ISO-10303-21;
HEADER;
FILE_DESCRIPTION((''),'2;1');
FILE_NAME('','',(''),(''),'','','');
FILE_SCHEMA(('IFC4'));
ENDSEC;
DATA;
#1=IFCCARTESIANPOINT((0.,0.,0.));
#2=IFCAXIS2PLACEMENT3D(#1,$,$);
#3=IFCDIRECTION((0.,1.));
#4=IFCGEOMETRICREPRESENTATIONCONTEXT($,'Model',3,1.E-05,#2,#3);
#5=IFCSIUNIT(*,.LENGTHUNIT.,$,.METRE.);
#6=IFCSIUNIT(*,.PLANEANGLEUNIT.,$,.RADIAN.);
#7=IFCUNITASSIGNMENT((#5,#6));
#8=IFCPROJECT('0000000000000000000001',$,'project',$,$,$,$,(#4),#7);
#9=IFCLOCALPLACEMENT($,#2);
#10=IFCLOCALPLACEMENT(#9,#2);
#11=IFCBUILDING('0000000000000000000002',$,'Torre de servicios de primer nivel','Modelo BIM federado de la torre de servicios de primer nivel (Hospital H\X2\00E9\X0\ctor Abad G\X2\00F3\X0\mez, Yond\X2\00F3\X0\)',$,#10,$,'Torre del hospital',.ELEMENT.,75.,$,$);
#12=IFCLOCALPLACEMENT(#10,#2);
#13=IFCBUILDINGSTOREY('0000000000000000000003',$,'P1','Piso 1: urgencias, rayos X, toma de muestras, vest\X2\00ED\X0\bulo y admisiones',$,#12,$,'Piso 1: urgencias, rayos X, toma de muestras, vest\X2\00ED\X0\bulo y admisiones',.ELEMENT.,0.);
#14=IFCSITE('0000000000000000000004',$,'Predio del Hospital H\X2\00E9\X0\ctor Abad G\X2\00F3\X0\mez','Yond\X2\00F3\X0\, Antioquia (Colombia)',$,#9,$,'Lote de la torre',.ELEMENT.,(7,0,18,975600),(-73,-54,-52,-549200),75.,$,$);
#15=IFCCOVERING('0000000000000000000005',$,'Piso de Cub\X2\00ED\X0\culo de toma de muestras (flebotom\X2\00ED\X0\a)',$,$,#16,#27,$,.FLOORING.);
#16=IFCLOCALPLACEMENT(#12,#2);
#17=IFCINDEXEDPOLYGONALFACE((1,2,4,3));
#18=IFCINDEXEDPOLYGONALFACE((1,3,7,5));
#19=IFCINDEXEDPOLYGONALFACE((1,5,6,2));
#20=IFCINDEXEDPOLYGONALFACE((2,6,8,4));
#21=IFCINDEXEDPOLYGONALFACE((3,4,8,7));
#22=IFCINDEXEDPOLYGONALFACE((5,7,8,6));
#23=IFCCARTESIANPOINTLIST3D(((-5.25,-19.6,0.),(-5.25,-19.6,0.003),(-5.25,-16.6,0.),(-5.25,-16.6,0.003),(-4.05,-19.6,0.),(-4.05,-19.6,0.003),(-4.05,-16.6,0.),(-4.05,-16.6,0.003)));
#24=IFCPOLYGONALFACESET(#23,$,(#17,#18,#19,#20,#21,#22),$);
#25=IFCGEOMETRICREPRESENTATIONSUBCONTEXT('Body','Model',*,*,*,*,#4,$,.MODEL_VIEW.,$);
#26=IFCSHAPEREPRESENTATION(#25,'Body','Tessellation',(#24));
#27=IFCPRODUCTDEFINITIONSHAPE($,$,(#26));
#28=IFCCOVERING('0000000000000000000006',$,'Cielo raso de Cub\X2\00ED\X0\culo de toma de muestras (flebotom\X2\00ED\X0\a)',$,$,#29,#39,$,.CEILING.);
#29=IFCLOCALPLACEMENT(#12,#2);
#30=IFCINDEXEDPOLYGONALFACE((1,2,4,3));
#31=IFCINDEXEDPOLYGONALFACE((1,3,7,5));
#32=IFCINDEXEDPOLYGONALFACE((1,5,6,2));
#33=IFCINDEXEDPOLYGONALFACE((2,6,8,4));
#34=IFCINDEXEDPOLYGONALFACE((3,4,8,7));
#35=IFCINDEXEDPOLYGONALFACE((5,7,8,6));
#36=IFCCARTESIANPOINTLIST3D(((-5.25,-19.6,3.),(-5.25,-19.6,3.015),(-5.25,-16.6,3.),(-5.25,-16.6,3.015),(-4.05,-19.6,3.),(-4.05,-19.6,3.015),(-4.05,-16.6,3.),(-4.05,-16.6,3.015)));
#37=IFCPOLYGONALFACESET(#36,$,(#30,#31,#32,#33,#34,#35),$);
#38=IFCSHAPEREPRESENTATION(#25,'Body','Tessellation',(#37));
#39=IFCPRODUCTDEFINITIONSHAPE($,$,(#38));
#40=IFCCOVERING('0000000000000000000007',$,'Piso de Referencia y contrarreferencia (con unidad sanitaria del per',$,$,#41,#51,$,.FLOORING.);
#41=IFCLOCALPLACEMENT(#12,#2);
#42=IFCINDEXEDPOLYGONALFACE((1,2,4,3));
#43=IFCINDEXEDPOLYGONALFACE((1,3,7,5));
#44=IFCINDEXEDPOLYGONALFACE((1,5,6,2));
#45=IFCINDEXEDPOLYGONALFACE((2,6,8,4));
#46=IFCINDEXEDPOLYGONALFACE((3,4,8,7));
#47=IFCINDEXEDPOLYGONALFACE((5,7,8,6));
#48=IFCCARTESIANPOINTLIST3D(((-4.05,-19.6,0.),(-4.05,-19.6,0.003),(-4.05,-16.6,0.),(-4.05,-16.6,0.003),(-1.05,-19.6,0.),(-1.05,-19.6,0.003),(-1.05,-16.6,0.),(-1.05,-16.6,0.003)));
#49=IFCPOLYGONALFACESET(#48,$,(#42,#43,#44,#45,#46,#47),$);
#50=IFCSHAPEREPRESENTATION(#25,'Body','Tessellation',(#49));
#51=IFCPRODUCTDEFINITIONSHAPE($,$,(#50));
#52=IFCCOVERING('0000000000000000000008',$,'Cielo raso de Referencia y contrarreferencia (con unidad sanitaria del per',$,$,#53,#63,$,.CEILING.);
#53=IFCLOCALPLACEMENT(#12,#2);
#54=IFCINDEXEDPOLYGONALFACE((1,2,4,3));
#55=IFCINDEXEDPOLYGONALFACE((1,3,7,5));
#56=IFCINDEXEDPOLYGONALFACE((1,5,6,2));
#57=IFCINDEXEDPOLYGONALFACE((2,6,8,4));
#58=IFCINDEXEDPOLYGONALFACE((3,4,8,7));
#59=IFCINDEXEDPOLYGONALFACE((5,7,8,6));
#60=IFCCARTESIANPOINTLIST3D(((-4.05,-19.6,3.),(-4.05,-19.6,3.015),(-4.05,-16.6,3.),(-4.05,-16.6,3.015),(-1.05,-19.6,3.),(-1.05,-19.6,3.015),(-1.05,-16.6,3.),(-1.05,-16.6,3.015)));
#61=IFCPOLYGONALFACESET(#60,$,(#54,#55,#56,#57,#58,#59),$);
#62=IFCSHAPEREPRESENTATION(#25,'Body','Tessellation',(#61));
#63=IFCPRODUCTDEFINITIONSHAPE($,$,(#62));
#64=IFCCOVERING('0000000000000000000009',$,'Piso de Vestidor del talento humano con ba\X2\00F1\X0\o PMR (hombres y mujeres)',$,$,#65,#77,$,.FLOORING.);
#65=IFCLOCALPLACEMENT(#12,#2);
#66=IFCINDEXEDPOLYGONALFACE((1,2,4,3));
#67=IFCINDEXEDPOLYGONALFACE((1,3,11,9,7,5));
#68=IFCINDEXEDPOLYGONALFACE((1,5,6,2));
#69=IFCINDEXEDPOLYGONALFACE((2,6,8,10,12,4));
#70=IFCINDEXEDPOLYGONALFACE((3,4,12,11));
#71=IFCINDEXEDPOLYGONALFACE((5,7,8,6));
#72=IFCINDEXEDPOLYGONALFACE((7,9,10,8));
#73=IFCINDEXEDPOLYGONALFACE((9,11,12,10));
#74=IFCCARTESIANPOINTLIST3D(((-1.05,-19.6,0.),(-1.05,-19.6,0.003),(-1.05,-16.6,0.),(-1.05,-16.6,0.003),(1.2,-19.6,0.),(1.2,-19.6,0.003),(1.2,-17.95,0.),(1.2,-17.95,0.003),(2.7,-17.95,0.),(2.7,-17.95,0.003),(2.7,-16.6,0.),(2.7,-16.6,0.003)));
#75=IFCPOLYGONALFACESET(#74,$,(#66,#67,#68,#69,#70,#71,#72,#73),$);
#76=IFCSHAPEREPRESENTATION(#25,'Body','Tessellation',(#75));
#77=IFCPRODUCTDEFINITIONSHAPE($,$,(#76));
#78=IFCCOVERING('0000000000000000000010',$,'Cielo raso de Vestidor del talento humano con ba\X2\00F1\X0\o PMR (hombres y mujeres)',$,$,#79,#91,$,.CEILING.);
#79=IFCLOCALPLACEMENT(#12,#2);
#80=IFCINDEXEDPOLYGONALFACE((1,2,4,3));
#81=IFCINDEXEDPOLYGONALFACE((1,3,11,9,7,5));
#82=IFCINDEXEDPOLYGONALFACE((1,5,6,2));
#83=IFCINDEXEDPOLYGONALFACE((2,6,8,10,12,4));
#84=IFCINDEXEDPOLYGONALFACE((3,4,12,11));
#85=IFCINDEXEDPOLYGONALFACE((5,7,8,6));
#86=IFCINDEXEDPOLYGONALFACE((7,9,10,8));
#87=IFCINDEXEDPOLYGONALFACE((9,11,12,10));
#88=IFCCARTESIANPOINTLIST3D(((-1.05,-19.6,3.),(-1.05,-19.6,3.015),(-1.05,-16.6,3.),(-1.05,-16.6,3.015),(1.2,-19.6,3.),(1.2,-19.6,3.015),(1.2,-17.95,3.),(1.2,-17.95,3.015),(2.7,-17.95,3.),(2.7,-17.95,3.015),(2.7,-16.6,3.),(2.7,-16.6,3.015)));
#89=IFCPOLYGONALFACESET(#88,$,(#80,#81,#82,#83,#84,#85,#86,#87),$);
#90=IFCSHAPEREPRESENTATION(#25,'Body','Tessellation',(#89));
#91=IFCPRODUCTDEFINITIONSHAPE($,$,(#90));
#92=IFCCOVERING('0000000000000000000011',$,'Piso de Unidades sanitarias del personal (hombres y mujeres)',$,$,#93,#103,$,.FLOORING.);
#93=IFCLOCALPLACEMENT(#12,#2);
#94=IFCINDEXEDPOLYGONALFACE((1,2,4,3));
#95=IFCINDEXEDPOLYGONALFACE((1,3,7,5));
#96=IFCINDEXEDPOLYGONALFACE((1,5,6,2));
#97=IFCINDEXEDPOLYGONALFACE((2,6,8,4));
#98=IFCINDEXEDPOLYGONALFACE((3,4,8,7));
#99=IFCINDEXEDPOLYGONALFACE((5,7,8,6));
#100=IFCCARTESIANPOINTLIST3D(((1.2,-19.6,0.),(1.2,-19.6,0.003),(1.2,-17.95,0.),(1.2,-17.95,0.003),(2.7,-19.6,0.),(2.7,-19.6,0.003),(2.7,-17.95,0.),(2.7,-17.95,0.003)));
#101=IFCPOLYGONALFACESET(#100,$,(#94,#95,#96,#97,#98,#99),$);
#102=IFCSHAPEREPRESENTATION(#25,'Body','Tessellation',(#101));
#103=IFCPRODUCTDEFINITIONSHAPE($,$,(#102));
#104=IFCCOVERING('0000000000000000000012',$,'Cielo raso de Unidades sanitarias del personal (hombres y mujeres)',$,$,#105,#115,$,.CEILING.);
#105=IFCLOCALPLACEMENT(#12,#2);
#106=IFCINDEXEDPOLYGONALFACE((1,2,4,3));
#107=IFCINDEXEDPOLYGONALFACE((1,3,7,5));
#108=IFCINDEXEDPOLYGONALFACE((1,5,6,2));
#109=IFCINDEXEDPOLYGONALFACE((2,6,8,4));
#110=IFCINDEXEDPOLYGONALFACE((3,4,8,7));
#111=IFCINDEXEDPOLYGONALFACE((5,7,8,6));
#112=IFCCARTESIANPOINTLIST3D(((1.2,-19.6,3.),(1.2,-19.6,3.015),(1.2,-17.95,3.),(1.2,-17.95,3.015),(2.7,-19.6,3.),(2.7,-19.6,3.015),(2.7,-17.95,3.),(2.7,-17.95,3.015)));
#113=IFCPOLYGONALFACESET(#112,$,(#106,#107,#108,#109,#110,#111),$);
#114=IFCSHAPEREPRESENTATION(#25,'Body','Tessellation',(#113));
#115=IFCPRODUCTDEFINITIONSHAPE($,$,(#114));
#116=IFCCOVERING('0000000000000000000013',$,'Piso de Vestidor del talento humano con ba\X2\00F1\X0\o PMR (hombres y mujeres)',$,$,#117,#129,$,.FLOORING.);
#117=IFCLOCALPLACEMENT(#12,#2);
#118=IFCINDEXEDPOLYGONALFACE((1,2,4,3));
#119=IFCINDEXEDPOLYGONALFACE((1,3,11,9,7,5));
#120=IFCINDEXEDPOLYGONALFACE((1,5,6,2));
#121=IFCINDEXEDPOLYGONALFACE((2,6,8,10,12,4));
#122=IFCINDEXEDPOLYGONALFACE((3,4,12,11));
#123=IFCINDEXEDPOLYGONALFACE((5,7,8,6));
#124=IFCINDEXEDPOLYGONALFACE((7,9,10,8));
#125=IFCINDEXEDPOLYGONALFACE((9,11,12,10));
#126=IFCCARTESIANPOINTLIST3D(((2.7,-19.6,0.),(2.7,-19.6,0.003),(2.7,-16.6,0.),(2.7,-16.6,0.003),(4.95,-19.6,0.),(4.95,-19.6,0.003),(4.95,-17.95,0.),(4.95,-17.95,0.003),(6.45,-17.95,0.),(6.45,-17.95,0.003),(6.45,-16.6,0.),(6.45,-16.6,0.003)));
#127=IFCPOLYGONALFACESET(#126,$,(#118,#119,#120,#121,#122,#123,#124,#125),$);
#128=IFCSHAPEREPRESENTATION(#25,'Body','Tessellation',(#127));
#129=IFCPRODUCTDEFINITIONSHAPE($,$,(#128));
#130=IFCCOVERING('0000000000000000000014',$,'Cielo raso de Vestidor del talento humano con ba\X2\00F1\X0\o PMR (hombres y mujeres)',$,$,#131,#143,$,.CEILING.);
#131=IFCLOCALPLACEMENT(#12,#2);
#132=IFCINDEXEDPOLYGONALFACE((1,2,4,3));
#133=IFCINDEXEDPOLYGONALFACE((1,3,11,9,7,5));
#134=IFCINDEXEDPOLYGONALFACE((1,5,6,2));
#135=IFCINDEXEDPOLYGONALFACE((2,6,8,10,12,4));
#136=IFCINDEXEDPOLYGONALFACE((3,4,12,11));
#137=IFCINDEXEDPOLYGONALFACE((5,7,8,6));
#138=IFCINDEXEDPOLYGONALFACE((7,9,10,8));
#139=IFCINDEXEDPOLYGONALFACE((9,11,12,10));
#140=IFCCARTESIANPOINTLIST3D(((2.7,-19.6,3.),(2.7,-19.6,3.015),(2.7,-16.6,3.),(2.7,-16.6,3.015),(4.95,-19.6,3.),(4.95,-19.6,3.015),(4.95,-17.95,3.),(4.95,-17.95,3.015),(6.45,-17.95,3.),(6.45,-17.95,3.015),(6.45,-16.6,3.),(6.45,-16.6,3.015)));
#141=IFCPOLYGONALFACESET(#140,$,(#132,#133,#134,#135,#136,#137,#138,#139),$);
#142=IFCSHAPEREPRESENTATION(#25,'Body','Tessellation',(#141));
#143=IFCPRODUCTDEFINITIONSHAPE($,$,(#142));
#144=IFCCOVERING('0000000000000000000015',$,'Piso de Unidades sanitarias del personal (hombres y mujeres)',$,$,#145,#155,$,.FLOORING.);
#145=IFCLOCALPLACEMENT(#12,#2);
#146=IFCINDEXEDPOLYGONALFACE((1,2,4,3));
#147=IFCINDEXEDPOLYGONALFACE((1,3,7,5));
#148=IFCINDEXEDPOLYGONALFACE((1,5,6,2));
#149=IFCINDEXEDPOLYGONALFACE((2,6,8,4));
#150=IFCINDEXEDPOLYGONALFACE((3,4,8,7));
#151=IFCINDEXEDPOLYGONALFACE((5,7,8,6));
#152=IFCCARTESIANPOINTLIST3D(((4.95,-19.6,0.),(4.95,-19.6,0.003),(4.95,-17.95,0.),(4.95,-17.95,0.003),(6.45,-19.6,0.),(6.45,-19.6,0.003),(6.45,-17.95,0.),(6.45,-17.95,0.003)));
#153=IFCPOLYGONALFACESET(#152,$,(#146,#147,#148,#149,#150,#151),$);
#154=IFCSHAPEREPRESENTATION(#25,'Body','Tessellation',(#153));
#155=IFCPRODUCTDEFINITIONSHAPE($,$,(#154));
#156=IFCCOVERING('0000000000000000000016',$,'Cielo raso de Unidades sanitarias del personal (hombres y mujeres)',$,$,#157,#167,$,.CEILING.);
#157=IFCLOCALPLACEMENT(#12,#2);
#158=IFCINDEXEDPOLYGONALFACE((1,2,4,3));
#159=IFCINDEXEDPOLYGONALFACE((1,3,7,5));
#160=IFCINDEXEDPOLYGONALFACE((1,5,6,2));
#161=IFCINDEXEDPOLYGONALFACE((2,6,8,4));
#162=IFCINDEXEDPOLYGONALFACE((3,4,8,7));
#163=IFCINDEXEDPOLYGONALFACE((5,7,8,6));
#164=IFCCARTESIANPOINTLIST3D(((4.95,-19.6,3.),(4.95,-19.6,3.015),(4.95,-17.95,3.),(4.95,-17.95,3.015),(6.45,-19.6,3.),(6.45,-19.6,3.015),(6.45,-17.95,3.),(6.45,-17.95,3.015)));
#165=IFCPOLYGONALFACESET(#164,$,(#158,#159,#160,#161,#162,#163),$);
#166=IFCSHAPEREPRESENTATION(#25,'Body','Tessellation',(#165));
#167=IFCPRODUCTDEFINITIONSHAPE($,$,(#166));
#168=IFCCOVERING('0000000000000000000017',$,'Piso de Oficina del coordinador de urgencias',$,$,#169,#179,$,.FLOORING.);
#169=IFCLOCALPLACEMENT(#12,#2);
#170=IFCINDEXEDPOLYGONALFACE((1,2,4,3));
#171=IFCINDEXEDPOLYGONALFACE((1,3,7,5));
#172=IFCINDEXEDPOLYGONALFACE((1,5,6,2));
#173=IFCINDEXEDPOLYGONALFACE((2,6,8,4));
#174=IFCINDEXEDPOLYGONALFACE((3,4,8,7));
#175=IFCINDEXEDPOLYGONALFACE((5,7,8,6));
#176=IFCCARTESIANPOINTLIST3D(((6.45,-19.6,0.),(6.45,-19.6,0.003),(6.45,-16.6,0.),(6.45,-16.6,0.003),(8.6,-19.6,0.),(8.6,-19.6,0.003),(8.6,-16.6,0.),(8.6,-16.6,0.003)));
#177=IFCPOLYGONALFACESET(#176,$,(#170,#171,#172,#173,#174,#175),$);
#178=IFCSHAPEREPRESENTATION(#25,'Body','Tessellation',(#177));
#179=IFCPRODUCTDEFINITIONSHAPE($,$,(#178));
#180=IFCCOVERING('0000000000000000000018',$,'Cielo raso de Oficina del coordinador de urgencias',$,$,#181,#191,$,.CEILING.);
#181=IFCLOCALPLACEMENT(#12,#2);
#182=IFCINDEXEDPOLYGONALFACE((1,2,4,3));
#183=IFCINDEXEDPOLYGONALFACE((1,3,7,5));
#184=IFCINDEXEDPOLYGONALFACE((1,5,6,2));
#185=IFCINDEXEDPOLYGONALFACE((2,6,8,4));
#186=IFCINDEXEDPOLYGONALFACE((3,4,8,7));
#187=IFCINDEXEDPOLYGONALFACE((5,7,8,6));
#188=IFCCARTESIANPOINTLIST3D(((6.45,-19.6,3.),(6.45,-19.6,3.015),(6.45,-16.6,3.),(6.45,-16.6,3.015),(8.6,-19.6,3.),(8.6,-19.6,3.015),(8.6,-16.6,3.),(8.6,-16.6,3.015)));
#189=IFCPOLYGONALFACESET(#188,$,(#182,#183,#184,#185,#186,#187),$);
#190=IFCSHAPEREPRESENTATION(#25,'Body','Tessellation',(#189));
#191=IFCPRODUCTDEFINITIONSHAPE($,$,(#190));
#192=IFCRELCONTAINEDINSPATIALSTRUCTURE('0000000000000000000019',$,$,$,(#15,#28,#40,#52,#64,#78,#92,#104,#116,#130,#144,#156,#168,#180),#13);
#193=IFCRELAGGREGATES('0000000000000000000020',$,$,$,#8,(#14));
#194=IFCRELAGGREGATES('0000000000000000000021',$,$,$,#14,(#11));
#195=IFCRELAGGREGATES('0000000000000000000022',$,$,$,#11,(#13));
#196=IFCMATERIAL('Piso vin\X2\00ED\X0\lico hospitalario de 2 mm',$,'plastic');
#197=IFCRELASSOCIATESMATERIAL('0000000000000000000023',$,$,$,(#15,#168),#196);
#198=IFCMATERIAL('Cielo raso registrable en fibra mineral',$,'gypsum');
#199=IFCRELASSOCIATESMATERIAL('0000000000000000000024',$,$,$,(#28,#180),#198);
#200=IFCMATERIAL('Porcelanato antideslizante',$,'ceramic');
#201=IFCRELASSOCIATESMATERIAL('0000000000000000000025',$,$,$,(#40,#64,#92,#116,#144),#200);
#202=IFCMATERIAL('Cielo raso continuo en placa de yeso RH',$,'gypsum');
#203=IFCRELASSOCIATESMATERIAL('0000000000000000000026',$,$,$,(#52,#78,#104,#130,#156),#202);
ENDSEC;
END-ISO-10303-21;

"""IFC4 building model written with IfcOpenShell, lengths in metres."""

from ifc_helpers import new_model, si_unit, direction, frame, origin, place, context, subcontext, project, spatial, indexed_curve, outline, extrude, material, element, save


model = new_model("IFC4")

# Units and contexts
model_context = context("Model", 3, precision=1e-05, world=origin(), true_north=direction((0.0, 1.0)))
body_context = subcontext(model_context, "Body", "Model", "MODEL_VIEW")
ifc_project = project(units=[si_unit("LENGTHUNIT", "METRE"), si_unit("PLANEANGLEUNIT", "RADIAN")], contexts=[model_context])

# Site, building, storey
site_placement = place(None, origin())
site = spatial("IfcSite", under=ifc_project, at=site_placement, Name="Predio del Hospital Héctor Abad Gómez", Description="Yondó, Antioquia (Colombia)", LongName="Lote de la torre", CompositionType="ELEMENT", RefLatitude=(7, 0, 18, 975600), RefLongitude=(-73, -54, -52, -549200), RefElevation=75.0)
building_placement = place(site_placement, origin())
building = spatial("IfcBuilding", under=site, at=building_placement, Name="Torre de servicios de primer nivel", Description="Modelo BIM federado de la torre de servicios de primer nivel (Hospital Héctor Abad Gómez, Yondó)", LongName="Torre del hospital", CompositionType="ELEMENT", ElevationOfRefHeight=75.0)
placement = place(building_placement, origin())
storey = spatial("IfcBuildingStorey", under=building, at=placement, Name="P1", Description="Piso 1: urgencias, rayos X, toma de muestras, vestíbulo y admisiones", LongName="Piso 1: urgencias, rayos X, toma de muestras, vestíbulo y admisiones", CompositionType="ELEMENT", Elevation=0.0)

# Coverings
ifc_material_1 = material(Name="Cielo raso continuo en placa de yeso RH", Category="gypsum")
ifc_material_2 = material(Name="Piso vinílico hospitalario de 2 mm", Category="plastic")
ifc_material_3 = material(Name="Cielo raso registrable en fibra mineral", Category="gypsum")
ifc_material_4 = material(Name="Porcelanato antideslizante", Category="ceramic")
element("IfcCovering", 1, at=placement, inside=storey, material=ifc_material_2, Name="Piso de Cubículo de toma de muestras (flebotomía)", PredefinedType="FLOORING", context=body_context, shape_type="SweptSolid", body=[
    extrude(outline(indexed_curve([(-5.25, -19.6), (-4.05, -19.6), (-4.05, -16.6), (-5.25, -16.6), (-5.25, -19.6)], self_intersect=False)), origin(), (0.0, 0.0, 1.0), 0.003),
])
element("IfcCovering", 2, at=placement, inside=storey, material=ifc_material_3, Name="Cielo raso de Cubículo de toma de muestras (flebotomía)", PredefinedType="CEILING", context=body_context, shape_type="SweptSolid", body=[
    extrude(outline(indexed_curve([(-5.25, -19.6), (-4.05, -19.6), (-4.05, -16.6), (-5.25, -16.6), (-5.25, -19.6)], self_intersect=False)), frame((0.0, 0.0, 3.0)), (0.0, 0.0, 1.0), 0.015),
])
element("IfcCovering", 3, at=placement, inside=storey, material=ifc_material_4, Name="Piso de Referencia y contrarreferencia (con unidad sanitaria del per", PredefinedType="FLOORING", context=body_context, shape_type="SweptSolid", body=[
    extrude(outline(indexed_curve([(-4.05, -19.6), (-1.05, -19.6), (-1.05, -16.6), (-4.05, -16.6), (-4.05, -19.6)], self_intersect=False)), origin(), (0.0, 0.0, 1.0), 0.003),
])
element("IfcCovering", 4, at=placement, inside=storey, material=ifc_material_1, Name="Cielo raso de Referencia y contrarreferencia (con unidad sanitaria del per", PredefinedType="CEILING", context=body_context, shape_type="SweptSolid", body=[
    extrude(outline(indexed_curve([(-4.05, -19.6), (-1.05, -19.6), (-1.05, -16.6), (-4.05, -16.6), (-4.05, -19.6)], self_intersect=False)), frame((0.0, 0.0, 3.0)), (0.0, 0.0, 1.0), 0.015),
])
element("IfcCovering", 5, at=placement, inside=storey, material=ifc_material_4, Name="Piso de Vestidor del talento humano con baño PMR (hombres y mujeres)", PredefinedType="FLOORING", context=body_context, shape_type="SweptSolid", body=[
    extrude(outline(indexed_curve([(-1.05, -19.6), (1.2, -19.6), (1.2, -17.95), (2.7, -17.95), (2.7, -16.6), (-1.05, -16.6), (-1.05, -19.6)], self_intersect=False)), origin(), (0.0, 0.0, 1.0), 0.003),
])
element("IfcCovering", 6, at=placement, inside=storey, material=ifc_material_1, Name="Cielo raso de Vestidor del talento humano con baño PMR (hombres y mujeres)", PredefinedType="CEILING", context=body_context, shape_type="SweptSolid", body=[
    extrude(outline(indexed_curve([(-1.05, -19.6), (1.2, -19.6), (1.2, -17.95), (2.7, -17.95), (2.7, -16.6), (-1.05, -16.6), (-1.05, -19.6)], self_intersect=False)), frame((0.0, 0.0, 3.0)), (0.0, 0.0, 1.0), 0.015),
])
element("IfcCovering", 7, at=placement, inside=storey, material=ifc_material_4, Name="Piso de Unidades sanitarias del personal (hombres y mujeres)", PredefinedType="FLOORING", context=body_context, shape_type="SweptSolid", body=[
    extrude(outline(indexed_curve([(1.2, -19.6), (2.7, -19.6), (2.7, -17.95), (1.2, -17.95), (1.2, -19.6)], self_intersect=False)), origin(), (0.0, 0.0, 1.0), 0.003),
])
element("IfcCovering", 8, at=placement, inside=storey, material=ifc_material_1, Name="Cielo raso de Unidades sanitarias del personal (hombres y mujeres)", PredefinedType="CEILING", context=body_context, shape_type="SweptSolid", body=[
    extrude(outline(indexed_curve([(1.2, -19.6), (2.7, -19.6), (2.7, -17.95), (1.2, -17.95), (1.2, -19.6)], self_intersect=False)), frame((0.0, 0.0, 3.0)), (0.0, 0.0, 1.0), 0.015),
])
element("IfcCovering", 9, at=placement, inside=storey, material=ifc_material_4, Name="Piso de Vestidor del talento humano con baño PMR (hombres y mujeres)", PredefinedType="FLOORING", context=body_context, shape_type="SweptSolid", body=[
    extrude(outline(indexed_curve([(2.7, -19.6), (4.95, -19.6), (4.95, -17.95), (6.45, -17.95), (6.45, -16.6), (2.7, -16.6), (2.7, -19.6)], self_intersect=False)), origin(), (0.0, 0.0, 1.0), 0.003),
])
element("IfcCovering", 10, at=placement, inside=storey, material=ifc_material_1, Name="Cielo raso de Vestidor del talento humano con baño PMR (hombres y mujeres)", PredefinedType="CEILING", context=body_context, shape_type="SweptSolid", body=[
    extrude(outline(indexed_curve([(2.7, -19.6), (4.95, -19.6), (4.95, -17.95), (6.45, -17.95), (6.45, -16.6), (2.7, -16.6), (2.7, -19.6)], self_intersect=False)), frame((0.0, 0.0, 3.0)), (0.0, 0.0, 1.0), 0.015),
])
element("IfcCovering", 11, at=placement, inside=storey, material=ifc_material_4, Name="Piso de Unidades sanitarias del personal (hombres y mujeres)", PredefinedType="FLOORING", context=body_context, shape_type="SweptSolid", body=[
    extrude(outline(indexed_curve([(4.95, -19.6), (6.45, -19.6), (6.45, -17.95), (4.95, -17.95), (4.95, -19.6)], self_intersect=False)), origin(), (0.0, 0.0, 1.0), 0.003),
])
element("IfcCovering", 12, at=placement, inside=storey, material=ifc_material_1, Name="Cielo raso de Unidades sanitarias del personal (hombres y mujeres)", PredefinedType="CEILING", context=body_context, shape_type="SweptSolid", body=[
    extrude(outline(indexed_curve([(4.95, -19.6), (6.45, -19.6), (6.45, -17.95), (4.95, -17.95), (4.95, -19.6)], self_intersect=False)), frame((0.0, 0.0, 3.0)), (0.0, 0.0, 1.0), 0.015),
])
element("IfcCovering", 13, at=placement, inside=storey, material=ifc_material_2, Name="Piso de Oficina del coordinador de urgencias", PredefinedType="FLOORING", context=body_context, shape_type="SweptSolid", body=[
    extrude(outline(indexed_curve([(6.45, -19.6), (8.6, -19.6), (8.6, -16.6), (6.45, -16.6), (6.45, -19.6)], self_intersect=False)), origin(), (0.0, 0.0, 1.0), 0.003),
])
element("IfcCovering", 14, at=placement, inside=storey, material=ifc_material_3, Name="Cielo raso de Oficina del coordinador de urgencias", PredefinedType="CEILING", context=body_context, shape_type="SweptSolid", body=[
    extrude(outline(indexed_curve([(6.45, -19.6), (8.6, -19.6), (8.6, -16.6), (6.45, -16.6), (6.45, -19.6)], self_intersect=False)), frame((0.0, 0.0, 3.0)), (0.0, 0.0, 1.0), 0.015),
])

save(model, "model.ifc")
